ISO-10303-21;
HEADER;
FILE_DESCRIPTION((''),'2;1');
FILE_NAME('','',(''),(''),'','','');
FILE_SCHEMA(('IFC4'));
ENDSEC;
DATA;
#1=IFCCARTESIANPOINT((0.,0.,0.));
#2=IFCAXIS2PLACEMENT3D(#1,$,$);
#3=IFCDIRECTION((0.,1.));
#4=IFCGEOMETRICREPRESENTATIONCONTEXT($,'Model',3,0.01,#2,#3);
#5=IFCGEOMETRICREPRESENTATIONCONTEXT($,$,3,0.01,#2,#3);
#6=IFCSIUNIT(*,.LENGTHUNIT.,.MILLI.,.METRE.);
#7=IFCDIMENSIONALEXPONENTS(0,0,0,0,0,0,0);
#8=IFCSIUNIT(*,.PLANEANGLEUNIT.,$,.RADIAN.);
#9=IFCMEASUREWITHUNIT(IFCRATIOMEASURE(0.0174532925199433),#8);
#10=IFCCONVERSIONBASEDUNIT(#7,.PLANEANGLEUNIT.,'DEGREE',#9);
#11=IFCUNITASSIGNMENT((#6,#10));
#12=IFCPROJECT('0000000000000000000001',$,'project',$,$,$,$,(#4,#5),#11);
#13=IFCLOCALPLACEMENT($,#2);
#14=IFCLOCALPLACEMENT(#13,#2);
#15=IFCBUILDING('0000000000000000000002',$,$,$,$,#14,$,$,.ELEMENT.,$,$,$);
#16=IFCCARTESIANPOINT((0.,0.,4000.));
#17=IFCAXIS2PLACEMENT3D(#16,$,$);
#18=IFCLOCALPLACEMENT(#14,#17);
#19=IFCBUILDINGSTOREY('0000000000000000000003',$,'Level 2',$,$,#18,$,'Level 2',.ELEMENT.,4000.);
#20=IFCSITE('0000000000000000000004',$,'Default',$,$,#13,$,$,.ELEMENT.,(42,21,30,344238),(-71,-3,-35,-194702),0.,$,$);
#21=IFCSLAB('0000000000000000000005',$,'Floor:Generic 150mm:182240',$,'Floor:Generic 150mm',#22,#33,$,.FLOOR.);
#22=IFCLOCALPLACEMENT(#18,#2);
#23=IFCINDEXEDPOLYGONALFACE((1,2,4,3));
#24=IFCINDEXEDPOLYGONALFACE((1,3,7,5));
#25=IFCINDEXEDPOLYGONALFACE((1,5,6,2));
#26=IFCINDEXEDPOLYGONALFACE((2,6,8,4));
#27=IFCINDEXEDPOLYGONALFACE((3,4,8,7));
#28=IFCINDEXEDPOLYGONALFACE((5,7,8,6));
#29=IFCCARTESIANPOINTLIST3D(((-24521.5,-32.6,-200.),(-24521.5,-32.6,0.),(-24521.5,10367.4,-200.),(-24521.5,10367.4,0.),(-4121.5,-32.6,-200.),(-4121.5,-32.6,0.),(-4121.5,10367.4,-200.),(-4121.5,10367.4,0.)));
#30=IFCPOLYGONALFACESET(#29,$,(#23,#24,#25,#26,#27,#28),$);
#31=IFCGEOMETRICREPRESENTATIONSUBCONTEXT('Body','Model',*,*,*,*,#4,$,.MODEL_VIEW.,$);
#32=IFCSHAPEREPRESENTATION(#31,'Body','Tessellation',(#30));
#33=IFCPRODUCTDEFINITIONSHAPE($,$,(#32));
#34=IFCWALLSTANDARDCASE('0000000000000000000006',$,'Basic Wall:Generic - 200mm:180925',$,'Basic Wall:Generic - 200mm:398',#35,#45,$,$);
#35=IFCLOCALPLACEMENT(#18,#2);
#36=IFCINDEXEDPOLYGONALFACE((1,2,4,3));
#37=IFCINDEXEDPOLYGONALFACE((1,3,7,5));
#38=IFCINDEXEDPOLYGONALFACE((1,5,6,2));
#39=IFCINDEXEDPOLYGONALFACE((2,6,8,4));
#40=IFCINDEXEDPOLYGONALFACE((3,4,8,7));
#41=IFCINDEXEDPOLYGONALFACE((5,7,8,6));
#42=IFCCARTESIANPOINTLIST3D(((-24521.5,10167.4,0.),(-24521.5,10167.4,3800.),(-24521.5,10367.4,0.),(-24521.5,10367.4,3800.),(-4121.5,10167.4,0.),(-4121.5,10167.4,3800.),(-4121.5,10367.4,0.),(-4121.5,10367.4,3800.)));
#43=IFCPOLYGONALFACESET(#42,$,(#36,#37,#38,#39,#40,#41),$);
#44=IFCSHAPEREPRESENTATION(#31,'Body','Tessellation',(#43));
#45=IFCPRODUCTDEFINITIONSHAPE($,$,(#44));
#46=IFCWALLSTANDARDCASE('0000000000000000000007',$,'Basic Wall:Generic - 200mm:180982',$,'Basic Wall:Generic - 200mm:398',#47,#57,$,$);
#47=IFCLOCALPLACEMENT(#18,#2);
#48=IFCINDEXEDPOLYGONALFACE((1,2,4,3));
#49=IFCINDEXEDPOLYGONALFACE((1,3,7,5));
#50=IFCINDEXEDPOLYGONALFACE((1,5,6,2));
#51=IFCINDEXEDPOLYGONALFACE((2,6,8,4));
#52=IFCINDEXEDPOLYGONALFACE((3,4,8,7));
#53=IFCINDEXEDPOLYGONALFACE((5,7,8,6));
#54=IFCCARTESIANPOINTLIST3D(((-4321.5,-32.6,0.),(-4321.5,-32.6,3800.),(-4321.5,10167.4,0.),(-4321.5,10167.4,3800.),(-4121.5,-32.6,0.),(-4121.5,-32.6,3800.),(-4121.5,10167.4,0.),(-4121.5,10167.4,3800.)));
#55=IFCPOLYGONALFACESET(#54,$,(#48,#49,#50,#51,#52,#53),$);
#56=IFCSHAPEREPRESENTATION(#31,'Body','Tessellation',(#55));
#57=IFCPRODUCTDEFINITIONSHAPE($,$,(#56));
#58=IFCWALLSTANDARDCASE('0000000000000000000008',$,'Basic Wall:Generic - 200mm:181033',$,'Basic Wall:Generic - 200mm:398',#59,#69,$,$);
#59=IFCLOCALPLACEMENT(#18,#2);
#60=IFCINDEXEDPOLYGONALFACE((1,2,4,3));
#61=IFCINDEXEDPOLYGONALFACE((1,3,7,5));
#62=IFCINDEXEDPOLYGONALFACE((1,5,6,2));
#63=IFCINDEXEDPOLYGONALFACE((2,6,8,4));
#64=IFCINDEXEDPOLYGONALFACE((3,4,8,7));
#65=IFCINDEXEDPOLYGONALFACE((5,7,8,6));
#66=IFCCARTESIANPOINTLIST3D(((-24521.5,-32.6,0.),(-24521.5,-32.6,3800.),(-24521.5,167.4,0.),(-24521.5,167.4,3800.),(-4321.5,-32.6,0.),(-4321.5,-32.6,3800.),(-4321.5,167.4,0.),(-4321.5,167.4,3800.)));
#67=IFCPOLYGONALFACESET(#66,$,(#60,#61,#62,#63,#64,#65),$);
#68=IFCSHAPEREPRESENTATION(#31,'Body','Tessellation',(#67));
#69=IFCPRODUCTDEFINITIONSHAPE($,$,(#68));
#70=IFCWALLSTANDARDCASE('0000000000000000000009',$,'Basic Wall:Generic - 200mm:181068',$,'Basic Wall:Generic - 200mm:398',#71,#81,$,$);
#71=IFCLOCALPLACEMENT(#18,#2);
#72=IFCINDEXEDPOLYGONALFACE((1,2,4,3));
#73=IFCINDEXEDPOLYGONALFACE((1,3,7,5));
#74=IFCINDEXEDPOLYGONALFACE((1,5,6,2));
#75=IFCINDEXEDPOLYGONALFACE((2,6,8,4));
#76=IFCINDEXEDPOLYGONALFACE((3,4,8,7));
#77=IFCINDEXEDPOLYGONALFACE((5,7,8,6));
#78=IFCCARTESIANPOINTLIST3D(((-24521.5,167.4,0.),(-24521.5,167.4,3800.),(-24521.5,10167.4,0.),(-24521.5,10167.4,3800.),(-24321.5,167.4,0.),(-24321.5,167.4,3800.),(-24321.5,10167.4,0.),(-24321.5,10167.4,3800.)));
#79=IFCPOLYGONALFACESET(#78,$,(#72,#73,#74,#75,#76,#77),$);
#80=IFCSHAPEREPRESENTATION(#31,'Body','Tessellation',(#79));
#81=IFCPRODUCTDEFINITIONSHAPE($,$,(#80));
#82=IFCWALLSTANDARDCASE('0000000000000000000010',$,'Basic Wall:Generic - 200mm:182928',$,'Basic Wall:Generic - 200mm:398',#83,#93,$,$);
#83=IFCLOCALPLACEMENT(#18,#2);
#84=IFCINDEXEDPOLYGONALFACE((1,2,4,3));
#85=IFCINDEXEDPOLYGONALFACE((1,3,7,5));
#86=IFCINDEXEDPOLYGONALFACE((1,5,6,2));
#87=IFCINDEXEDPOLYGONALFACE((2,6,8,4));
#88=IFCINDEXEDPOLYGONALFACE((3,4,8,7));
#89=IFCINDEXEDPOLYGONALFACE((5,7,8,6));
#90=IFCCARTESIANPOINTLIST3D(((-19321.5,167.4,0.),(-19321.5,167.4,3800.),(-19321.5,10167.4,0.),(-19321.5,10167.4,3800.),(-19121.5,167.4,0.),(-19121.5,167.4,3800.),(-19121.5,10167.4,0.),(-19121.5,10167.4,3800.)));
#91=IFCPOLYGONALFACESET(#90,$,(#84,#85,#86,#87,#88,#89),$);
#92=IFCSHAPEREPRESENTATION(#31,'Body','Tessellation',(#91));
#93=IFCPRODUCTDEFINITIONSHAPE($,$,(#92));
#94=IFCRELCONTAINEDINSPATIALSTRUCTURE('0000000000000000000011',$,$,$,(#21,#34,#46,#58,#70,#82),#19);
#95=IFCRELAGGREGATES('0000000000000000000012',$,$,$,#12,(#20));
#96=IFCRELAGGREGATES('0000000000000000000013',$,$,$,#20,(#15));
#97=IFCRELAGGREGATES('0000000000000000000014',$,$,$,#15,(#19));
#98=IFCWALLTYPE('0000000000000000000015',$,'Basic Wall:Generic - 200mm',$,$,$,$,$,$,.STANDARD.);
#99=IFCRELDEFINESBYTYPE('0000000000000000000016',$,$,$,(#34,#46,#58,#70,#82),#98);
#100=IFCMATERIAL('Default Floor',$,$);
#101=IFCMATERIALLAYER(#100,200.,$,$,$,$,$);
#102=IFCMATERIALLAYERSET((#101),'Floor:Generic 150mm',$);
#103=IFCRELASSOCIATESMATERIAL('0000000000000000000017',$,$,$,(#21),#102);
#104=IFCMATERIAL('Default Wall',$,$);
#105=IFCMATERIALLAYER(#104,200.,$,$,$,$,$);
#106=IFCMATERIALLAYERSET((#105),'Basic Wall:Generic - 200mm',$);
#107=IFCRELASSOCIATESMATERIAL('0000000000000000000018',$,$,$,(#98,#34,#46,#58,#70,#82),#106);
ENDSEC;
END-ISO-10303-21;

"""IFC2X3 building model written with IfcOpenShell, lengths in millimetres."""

from ifc_helpers import new_model, entity, si_unit, converted_unit, direction, frame, frame_2d, origin, place, context, subcontext, project, spatial, rectangle, extrude, material, layer, layer_set, layer_usage, type_object, element, save


model = new_model("IFC2X3")

# Units and contexts
model_context = context("Model", 3, precision=0.01, world=origin(), true_north=direction((0.0, 1.0)))
context_of_model = context(None, 3, precision=0.01, world=origin(), true_north=direction((0.0, 1.0)))
body_context = subcontext(model_context, "Body", "Model", "MODEL_VIEW")
ifc_project = project(units=[si_unit("LENGTHUNIT", "METRE", prefix="MILLI"), converted_unit("PLANEANGLEUNIT", "DEGREE", entity("IfcRatioMeasure", 0.0174532925199433), si_unit("PLANEANGLEUNIT", "RADIAN"), dimensions=[0, 0, 0, 0, 0, 0, 0])], contexts=[model_context, context_of_model])

# Site, building, storey
site_placement = place(None, origin())
site = spatial("IfcSite", under=ifc_project, at=site_placement, Name="Default", CompositionType="ELEMENT", RefLatitude=(42, 21, 30, 344238), RefLongitude=(-71, -3, -35, -194702), RefElevation=0.0)
building_placement = place(site_placement, origin())
building = spatial("IfcBuilding", under=site, at=building_placement, CompositionType="ELEMENT")
storey_placement = place(building_placement, frame((0.0, 0.0, 4000.0)))
storey = spatial("IfcBuildingStorey", under=building, at=storey_placement, Name="Level 2", LongName="Level 2", CompositionType="ELEMENT", Elevation=4000.0)

# Slab
ifc_material_1 = material(Name="Default Floor")
ifc_layer_1 = layer(ifc_material_1, 200.0)
ifc_layer_set_1 = layer_set([ifc_layer_1], Name="Floor:Generic 150mm")
ifc_layer_usage_1 = layer_usage(ifc_layer_set_1, "AXIS3", "POSITIVE", 0.0)
slab_placement = place(storey_placement, origin())
element("IfcSlab", 1, at=slab_placement, inside=storey, material=ifc_layer_usage_1, Name="Floor:Generic 150mm:182240", ObjectType="Floor:Generic 150mm", PredefinedType="FLOOR", context=body_context, shape_type="SweptSolid", body=[
    extrude(rectangle(XDim=10400.0, YDim=20400.0, at=frame_2d((0.0, 0.0), x_axis=(1.0, 0.0))), frame((-14321.5, 5167.4, 0.0), z_axis=(0.0, 0.0, -1.0), x_axis=(0.0, 1.0, 0.0)), (0.0, 0.0, 1.0), 200.0),
])

# Walls
ifc_material_2 = material(Name="Default Wall")
ifc_layer_2 = layer(ifc_material_2, 200.0)
ifc_layer_set_2 = layer_set([ifc_layer_2], Name="Basic Wall:Generic - 200mm")
ifc_layer_usage_2 = layer_usage(ifc_layer_set_2, "AXIS2", "NEGATIVE", 100.0)
wall_type = type_object("IfcWallType", Name="Basic Wall:Generic - 200mm", PredefinedType="STANDARD", material=ifc_layer_set_2)
wall_1_placement = place(storey_placement, frame((-24521.5, 10267.4, 0.0)))
element("IfcWallStandardCase", 2, at=wall_1_placement, inside=storey, type_object=wall_type, material=ifc_layer_usage_2, Name="Basic Wall:Generic - 200mm:180925", ObjectType="Basic Wall:Generic - 200mm:398", context=body_context, shape_type="SweptSolid", body=[
    extrude(rectangle(XDim=20400.0, YDim=200.0, at=frame_2d((10200.0, 0.0), x_axis=(-1.0, 0.0))), origin(), (0.0, 0.0, 1.0), 3800.0),
])
ifc_layer_usage_3 = layer_usage(ifc_layer_set_2, "AXIS2", "NEGATIVE", 100.0)
wall_2_placement = place(storey_placement, frame((-4221.5, 10167.4, 0.0), z_axis=(0.0, 0.0, 1.0), x_axis=(0.0, -1.0, 0.0)))
element("IfcWallStandardCase", 3, at=wall_2_placement, inside=storey, type_object=wall_type, material=ifc_layer_usage_3, Name="Basic Wall:Generic - 200mm:180982", ObjectType="Basic Wall:Generic - 200mm:398", context=body_context, shape_type="SweptSolid", body=[
    extrude(rectangle(XDim=10200.0, YDim=200.0, at=frame_2d((5100.0, 0.0), x_axis=(-1.0, 0.0))), origin(), (0.0, 0.0, 1.0), 3800.0),
])
ifc_layer_usage_4 = layer_usage(ifc_layer_set_2, "AXIS2", "NEGATIVE", 100.0)
wall_3_placement = place(storey_placement, frame((-4321.5, 67.4, 0.0), z_axis=(0.0, 0.0, 1.0), x_axis=(-1.0, 0.0, 0.0)))
element("IfcWallStandardCase", 4, at=wall_3_placement, inside=storey, type_object=wall_type, material=ifc_layer_usage_4, Name="Basic Wall:Generic - 200mm:181033", ObjectType="Basic Wall:Generic - 200mm:398", context=body_context, shape_type="SweptSolid", body=[
    extrude(rectangle(XDim=20200.0, YDim=200.0, at=frame_2d((10100.0, 0.0), x_axis=(-1.0, 0.0))), origin(), (0.0, 0.0, 1.0), 3800.0),
])
ifc_layer_usage_5 = layer_usage(ifc_layer_set_2, "AXIS2", "NEGATIVE", 100.0)
wall_4_placement = place(storey_placement, frame((-24421.5, 167.4, 0.0), z_axis=(0.0, 0.0, 1.0), x_axis=(0.0, 1.0, 0.0)))
element("IfcWallStandardCase", 5, at=wall_4_placement, inside=storey, type_object=wall_type, material=ifc_layer_usage_5, Name="Basic Wall:Generic - 200mm:181068", ObjectType="Basic Wall:Generic - 200mm:398", context=body_context, shape_type="SweptSolid", body=[
    extrude(rectangle(XDim=10000.0, YDim=200.0, at=frame_2d((5000.0, 0.0), x_axis=(-1.0, 0.0))), origin(), (0.0, 0.0, 1.0), 3800.0),
])
ifc_layer_usage_6 = layer_usage(ifc_layer_set_2, "AXIS2", "NEGATIVE", 100.0)
wall_5_placement = place(storey_placement, frame((-19221.5, 10167.4, 0.0), z_axis=(0.0, 0.0, 1.0), x_axis=(0.0, -1.0, 0.0)))
element("IfcWallStandardCase", 6, at=wall_5_placement, inside=storey, type_object=wall_type, material=ifc_layer_usage_6, Name="Basic Wall:Generic - 200mm:182928", ObjectType="Basic Wall:Generic - 200mm:398", context=body_context, shape_type="SweptSolid", body=[
    extrude(rectangle(XDim=10000.0, YDim=200.0, at=frame_2d((5000.0, 0.0), x_axis=(-1.0, 0.0))), origin(), (0.0, 0.0, 1.0), 3800.0),
])

save(model, "model.ifc")
